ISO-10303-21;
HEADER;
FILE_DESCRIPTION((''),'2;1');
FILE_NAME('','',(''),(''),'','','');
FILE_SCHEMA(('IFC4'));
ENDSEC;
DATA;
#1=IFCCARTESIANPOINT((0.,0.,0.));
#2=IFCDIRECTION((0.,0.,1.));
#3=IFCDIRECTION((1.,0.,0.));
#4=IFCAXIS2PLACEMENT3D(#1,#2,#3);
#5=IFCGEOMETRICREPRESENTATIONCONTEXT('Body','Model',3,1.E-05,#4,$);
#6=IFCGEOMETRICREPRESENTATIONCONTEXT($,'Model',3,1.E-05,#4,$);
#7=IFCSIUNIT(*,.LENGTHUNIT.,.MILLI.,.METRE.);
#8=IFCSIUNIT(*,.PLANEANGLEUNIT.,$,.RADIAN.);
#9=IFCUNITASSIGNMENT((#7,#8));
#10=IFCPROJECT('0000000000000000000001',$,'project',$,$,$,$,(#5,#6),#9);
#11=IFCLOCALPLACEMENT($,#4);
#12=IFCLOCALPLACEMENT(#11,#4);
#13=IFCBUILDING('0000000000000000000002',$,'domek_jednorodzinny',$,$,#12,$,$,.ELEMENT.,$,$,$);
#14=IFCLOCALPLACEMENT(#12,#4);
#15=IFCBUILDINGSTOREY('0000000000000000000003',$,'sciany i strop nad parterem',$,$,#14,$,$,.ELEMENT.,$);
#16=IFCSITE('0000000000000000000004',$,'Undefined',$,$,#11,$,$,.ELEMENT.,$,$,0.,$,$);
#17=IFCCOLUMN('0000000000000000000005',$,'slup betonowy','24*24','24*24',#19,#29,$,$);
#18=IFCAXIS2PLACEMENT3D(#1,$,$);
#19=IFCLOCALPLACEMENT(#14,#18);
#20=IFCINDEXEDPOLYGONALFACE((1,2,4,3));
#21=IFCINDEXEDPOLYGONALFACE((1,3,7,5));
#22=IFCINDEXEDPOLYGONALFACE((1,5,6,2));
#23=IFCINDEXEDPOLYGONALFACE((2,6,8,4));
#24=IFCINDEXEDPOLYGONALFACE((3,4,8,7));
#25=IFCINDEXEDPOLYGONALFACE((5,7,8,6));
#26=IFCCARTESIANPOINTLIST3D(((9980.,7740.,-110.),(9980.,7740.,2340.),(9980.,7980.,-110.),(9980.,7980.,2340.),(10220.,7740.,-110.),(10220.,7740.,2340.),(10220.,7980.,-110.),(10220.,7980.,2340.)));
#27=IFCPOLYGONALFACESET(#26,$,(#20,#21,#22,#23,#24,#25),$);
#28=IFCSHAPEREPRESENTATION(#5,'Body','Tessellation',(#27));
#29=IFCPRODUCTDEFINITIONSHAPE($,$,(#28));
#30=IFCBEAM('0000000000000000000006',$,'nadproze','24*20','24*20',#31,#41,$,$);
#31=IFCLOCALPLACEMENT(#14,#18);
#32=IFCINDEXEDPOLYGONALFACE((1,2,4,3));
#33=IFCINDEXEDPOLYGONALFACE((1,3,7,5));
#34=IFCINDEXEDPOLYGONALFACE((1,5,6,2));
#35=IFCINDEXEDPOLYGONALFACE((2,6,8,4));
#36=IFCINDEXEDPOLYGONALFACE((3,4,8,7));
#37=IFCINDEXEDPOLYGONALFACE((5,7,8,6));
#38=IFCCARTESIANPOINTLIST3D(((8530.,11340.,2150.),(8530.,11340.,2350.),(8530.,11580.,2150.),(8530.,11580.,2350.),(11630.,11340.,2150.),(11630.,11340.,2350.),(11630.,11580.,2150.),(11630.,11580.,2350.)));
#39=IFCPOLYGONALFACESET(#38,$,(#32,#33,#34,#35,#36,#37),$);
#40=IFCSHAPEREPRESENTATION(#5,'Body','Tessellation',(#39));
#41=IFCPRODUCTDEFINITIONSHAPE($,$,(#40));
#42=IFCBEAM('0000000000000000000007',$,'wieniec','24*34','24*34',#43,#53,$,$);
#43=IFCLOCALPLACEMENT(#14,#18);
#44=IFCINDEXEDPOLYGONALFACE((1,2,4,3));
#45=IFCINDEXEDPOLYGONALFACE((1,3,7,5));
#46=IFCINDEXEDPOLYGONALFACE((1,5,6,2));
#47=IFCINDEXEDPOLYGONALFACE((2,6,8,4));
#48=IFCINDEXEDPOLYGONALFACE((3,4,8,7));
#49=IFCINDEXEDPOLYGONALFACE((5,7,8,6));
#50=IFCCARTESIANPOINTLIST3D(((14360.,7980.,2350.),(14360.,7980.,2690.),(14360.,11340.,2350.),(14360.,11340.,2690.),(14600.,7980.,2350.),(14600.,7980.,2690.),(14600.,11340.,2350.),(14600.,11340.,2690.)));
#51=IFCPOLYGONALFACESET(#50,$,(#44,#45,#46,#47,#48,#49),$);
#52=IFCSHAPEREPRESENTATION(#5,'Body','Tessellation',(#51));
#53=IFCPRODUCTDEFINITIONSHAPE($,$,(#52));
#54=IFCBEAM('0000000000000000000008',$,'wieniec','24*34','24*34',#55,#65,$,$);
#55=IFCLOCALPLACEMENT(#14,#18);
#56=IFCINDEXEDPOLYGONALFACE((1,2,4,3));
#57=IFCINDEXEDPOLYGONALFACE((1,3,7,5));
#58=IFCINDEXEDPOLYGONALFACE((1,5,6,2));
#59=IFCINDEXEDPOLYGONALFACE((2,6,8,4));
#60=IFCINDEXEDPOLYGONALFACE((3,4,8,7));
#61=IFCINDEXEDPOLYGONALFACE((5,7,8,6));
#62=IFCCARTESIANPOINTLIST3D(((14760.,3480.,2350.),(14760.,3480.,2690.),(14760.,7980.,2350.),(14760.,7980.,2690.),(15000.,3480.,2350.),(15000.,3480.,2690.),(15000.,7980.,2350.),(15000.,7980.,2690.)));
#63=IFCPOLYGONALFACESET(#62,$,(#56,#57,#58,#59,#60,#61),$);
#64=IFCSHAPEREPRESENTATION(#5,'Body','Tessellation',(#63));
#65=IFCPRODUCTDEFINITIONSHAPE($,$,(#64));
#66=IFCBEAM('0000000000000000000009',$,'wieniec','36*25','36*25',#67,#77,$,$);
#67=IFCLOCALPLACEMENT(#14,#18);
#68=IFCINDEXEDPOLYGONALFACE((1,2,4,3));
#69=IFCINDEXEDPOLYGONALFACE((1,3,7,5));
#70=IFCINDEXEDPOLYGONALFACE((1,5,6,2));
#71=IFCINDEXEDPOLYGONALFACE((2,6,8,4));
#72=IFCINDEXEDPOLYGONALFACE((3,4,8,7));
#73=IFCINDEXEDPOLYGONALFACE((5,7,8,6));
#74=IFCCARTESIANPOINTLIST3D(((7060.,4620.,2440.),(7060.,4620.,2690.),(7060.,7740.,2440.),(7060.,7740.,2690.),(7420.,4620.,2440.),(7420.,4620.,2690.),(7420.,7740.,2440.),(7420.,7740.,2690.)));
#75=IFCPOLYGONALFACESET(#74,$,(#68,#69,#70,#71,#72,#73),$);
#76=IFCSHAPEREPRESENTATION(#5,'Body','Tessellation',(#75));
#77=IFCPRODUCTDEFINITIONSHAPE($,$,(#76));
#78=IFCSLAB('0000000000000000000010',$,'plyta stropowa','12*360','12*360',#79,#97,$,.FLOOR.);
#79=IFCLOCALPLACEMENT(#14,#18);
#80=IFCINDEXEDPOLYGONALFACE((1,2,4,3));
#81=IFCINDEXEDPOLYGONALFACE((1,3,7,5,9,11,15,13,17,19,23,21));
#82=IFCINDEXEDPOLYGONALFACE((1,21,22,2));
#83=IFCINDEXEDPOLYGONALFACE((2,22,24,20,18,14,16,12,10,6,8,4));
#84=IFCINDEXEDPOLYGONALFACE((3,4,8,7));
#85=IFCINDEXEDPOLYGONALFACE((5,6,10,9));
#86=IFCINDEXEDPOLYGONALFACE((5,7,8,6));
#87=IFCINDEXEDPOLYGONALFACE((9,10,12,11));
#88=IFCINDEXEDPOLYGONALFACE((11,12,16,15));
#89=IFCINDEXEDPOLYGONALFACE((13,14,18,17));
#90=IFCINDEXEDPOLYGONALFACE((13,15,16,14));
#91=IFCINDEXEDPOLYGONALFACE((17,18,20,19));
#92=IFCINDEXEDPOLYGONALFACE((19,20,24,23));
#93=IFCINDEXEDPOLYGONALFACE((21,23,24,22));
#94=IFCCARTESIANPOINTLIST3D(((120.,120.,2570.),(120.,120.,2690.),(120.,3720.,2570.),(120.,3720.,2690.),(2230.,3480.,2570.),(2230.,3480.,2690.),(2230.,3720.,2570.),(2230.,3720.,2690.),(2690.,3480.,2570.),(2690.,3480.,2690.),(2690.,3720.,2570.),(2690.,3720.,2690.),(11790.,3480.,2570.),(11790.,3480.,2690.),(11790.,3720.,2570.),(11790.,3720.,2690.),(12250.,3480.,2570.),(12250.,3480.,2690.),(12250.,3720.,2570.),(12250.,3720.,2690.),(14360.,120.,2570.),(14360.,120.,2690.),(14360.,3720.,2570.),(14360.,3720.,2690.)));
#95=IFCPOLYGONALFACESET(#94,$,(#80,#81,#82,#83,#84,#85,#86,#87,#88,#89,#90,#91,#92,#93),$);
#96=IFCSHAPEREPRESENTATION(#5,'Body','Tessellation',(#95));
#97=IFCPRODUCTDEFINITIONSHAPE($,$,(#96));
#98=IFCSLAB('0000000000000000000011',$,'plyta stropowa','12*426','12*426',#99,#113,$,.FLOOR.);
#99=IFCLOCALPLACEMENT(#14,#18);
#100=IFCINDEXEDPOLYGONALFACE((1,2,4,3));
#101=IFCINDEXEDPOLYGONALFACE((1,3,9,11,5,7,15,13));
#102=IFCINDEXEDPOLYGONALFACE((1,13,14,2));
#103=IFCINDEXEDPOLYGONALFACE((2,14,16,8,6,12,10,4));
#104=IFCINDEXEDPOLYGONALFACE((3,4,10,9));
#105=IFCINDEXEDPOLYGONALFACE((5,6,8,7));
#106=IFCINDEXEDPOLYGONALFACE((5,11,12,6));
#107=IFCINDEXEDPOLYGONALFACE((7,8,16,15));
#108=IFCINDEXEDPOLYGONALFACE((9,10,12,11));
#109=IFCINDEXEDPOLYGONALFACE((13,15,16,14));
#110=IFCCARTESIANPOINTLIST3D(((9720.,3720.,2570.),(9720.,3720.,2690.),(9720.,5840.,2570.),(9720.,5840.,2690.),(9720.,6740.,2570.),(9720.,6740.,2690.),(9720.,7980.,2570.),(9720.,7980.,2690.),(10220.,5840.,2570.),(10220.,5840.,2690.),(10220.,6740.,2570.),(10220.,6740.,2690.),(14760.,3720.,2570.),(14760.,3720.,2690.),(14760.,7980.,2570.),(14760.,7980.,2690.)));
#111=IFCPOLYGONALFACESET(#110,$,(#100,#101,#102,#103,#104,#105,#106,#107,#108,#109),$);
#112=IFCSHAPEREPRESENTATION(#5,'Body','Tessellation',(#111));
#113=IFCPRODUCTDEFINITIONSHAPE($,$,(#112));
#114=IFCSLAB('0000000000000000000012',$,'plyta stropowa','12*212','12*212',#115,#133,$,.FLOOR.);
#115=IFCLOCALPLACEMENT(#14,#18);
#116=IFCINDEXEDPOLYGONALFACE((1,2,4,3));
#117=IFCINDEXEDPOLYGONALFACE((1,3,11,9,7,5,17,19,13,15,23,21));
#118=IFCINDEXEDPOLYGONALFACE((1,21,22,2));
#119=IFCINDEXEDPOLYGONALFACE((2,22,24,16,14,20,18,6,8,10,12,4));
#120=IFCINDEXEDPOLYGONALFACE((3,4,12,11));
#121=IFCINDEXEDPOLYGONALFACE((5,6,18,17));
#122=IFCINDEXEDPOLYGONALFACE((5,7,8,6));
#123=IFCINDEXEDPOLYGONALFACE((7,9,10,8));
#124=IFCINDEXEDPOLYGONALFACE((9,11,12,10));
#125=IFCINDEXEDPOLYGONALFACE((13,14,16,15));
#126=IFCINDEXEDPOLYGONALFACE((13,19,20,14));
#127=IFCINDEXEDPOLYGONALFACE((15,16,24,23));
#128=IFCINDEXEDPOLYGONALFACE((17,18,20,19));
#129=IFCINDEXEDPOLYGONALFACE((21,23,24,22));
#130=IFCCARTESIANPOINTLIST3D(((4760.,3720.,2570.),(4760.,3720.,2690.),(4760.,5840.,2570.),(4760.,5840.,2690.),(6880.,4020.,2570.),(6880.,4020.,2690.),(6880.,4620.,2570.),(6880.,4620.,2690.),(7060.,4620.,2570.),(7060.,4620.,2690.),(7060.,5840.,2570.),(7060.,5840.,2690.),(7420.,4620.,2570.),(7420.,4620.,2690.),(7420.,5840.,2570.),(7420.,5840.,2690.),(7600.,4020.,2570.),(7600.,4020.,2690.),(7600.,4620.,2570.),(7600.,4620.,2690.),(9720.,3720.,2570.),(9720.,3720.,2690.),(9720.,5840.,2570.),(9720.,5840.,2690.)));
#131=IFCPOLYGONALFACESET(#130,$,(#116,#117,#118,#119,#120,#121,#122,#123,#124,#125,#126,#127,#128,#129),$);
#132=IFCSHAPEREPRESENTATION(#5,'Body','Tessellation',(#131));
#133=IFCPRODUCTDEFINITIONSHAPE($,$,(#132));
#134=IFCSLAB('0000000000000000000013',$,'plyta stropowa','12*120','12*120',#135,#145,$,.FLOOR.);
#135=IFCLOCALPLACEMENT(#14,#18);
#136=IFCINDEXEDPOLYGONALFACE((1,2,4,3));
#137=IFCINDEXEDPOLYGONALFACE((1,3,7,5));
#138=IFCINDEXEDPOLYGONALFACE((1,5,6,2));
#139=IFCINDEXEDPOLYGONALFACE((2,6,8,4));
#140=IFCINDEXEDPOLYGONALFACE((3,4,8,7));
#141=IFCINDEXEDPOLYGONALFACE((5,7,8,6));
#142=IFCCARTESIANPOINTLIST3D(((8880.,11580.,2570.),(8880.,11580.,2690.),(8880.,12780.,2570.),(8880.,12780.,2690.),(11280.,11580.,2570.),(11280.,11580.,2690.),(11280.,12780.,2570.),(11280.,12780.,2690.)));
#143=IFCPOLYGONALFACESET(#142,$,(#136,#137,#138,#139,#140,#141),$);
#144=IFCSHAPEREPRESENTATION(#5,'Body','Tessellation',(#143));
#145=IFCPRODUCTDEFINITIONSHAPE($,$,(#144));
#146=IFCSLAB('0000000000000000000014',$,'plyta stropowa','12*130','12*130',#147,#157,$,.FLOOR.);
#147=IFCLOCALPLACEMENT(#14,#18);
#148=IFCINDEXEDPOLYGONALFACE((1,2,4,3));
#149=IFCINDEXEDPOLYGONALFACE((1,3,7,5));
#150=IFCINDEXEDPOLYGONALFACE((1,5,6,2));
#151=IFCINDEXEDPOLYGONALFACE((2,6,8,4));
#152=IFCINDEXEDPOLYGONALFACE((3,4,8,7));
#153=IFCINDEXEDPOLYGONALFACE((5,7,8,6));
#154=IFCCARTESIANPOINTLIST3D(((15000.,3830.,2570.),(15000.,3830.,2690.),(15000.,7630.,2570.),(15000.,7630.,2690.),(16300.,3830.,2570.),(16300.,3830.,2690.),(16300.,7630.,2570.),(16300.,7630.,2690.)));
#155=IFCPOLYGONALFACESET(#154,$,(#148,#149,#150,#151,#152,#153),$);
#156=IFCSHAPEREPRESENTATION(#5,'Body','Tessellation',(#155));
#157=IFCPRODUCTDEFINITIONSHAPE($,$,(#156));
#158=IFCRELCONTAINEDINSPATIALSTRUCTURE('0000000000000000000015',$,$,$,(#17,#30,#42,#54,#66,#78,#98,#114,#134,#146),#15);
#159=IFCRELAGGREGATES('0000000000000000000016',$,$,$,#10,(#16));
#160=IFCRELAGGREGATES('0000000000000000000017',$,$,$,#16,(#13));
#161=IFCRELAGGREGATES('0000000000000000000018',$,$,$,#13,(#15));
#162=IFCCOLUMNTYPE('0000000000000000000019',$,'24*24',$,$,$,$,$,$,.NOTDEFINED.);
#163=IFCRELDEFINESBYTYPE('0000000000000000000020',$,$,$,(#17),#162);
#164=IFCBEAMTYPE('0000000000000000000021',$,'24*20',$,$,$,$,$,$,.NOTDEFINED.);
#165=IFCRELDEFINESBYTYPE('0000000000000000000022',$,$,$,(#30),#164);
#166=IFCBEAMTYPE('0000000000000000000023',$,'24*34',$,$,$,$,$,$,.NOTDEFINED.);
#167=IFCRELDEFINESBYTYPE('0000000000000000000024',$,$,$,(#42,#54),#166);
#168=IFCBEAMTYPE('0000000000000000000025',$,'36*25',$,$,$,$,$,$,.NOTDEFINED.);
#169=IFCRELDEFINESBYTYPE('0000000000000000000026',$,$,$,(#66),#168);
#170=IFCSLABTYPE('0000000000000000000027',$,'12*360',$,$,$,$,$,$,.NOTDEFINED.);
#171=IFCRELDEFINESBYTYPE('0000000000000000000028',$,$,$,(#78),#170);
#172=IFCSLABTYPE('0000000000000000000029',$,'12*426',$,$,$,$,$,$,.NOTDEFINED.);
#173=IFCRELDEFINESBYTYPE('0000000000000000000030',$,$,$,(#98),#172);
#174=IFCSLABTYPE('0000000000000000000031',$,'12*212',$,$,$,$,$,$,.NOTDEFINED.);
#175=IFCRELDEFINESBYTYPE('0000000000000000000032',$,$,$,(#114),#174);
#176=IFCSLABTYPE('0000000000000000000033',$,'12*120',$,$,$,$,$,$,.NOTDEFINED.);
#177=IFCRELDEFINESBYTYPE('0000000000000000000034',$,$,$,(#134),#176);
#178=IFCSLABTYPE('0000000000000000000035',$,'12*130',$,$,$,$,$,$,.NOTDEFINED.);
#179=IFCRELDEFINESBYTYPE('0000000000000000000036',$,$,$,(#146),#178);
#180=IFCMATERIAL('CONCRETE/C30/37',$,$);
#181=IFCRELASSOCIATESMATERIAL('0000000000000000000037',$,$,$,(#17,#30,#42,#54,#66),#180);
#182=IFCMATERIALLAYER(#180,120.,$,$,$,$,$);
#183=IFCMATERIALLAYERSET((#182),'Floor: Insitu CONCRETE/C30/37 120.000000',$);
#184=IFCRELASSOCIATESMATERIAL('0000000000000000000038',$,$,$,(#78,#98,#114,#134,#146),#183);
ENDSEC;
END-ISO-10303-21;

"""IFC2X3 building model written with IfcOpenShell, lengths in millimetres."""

from ifc_helpers import new_model, si_unit, frame, origin_with_axes, origin_2d_with_axis, place, context, project, spatial, polyline, rectangle, outline, extrude, material, layer, layer_set, layer_usage, type_object, element, save


model = new_model("IFC2X3")

# Units and contexts
model_context_1 = context("Model", 3, precision=1e-05, world=origin_with_axes(), identifier="Body")
model_context_2 = context("Model", 3, precision=1e-05, world=origin_with_axes())
ifc_project = project(units=[si_unit("LENGTHUNIT", "METRE", prefix="MILLI"), si_unit("PLANEANGLEUNIT", "RADIAN")], contexts=[model_context_1, model_context_2])

# Site, building, storey
site_placement = place(None, origin_with_axes())
site = spatial("IfcSite", under=ifc_project, at=site_placement, Name="Undefined", CompositionType="ELEMENT", RefElevation=0.0)
building_placement = place(site_placement, origin_with_axes())
building = spatial("IfcBuilding", under=site, at=building_placement, Name="domek_jednorodzinny", CompositionType="ELEMENT")
storey_placement = place(building_placement, origin_with_axes())
storey = spatial("IfcBuildingStorey", under=building, at=storey_placement, Name="sciany i strop nad parterem", CompositionType="ELEMENT")

# Column
ifc_material_1 = material(Name="CONCRETE/C30/37")
column_type = type_object("IfcColumnType", Name="24*24", PredefinedType="NOTDEFINED")
column_placement = place(storey_placement, frame((10100.0, 7860.0, -110.0), z_axis=(0.0, 0.0, 1.0), x_axis=(1.0, 0.0, 0.0)))
element("IfcColumn", 1, at=column_placement, inside=storey, type_object=column_type, material=ifc_material_1, Name="slup betonowy", Description="24*24", ObjectType="24*24", context=model_context_1, shape_type="SweptSolid", body=[
    extrude(rectangle(XDim=240.0, YDim=240.0, at=origin_2d_with_axis()), frame((0.0, 0.0, 2450.0), z_axis=(0.000001, 0.000001, -1.0), x_axis=(-1.0, 0.0, 0.0)), (0.0, 0.0, 1.0), 2450.0),
])

# Beams
beam_type_1 = type_object("IfcBeamType", Name="24*20", PredefinedType="NOTDEFINED")
beam_1_placement = place(storey_placement, frame((8530.0, 11460.0, 2250.0), z_axis=(0.0, 0.0, 1.0), x_axis=(1.0, 0.0, 0.0)))
element("IfcBeam", 2, at=beam_1_placement, inside=storey, type_object=beam_type_1, material=ifc_material_1, Name="nadproze", Description="24*20", ObjectType="24*20", context=model_context_1, shape_type="SweptSolid", body=[
    extrude(rectangle(XDim=240.0, YDim=200.0, at=origin_2d_with_axis()), frame((3100.0, 0.0, 0.0), z_axis=(-1.0, 0.0, 0.0), x_axis=(0.0, -1.0, 0.0)), (0.0, 0.0, 1.0), 3100.0),
])
beam_type_2 = type_object("IfcBeamType", Name="24*34", PredefinedType="NOTDEFINED")
beam_2_placement = place(storey_placement, frame((14480.0, 11340.0, 2520.0), z_axis=(0.0, 0.0, 1.0), x_axis=(0.0, -1.0, 0.0)))
element("IfcBeam", 3, at=beam_2_placement, inside=storey, type_object=beam_type_2, material=ifc_material_1, Name="wieniec", Description="24*34", ObjectType="24*34", context=model_context_1, shape_type="SweptSolid", body=[
    extrude(rectangle(XDim=240.0, YDim=340.0, at=origin_2d_with_axis()), frame((3360.0, 0.0, 0.0), z_axis=(-1.0, 0.0, 0.0), x_axis=(0.0, -1.0, 0.0)), (0.0, 0.0, 1.0), 3360.0),
])
beam_3_placement = place(storey_placement, frame((14880.0, 7980.0, 2520.0), z_axis=(0.0, 0.0, 1.0), x_axis=(0.0, -1.0, 0.0)))
element("IfcBeam", 4, at=beam_3_placement, inside=storey, type_object=beam_type_2, material=ifc_material_1, Name="wieniec", Description="24*34", ObjectType="24*34", context=model_context_1, shape_type="SweptSolid", body=[
    extrude(rectangle(XDim=240.0, YDim=340.0, at=origin_2d_with_axis()), frame((4500.0, 0.0, 0.0), z_axis=(-1.0, 0.0, 0.0), x_axis=(0.0, -1.0, 0.0)), (0.0, 0.0, 1.0), 4500.0),
])
beam_type_3 = type_object("IfcBeamType", Name="36*25", PredefinedType="NOTDEFINED")
beam_4_placement = place(storey_placement, frame((7240.0, 4620.0, 2565.0), z_axis=(0.0, 0.0, 1.0), x_axis=(0.0, 1.0, 0.0)))
element("IfcBeam", 5, at=beam_4_placement, inside=storey, type_object=beam_type_3, material=ifc_material_1, Name="wieniec", Description="36*25", ObjectType="36*25", context=model_context_1, shape_type="SweptSolid", body=[
    extrude(rectangle(XDim=360.0, YDim=250.0, at=origin_2d_with_axis()), frame((3120.0, 0.0, 0.0), z_axis=(-1.0, 0.0, 0.0), x_axis=(0.0, -1.0, 0.0)), (0.0, 0.0, 1.0), 3120.0),
])

# Slab, openings
ifc_layer_1 = layer(ifc_material_1, 120.0)
ifc_layer_set_1 = layer_set([ifc_layer_1], Name="Floor: Insitu CONCRETE/C30/37 120.000000")
ifc_layer_usage_1 = layer_usage(ifc_layer_set_1, "AXIS3", "POSITIVE", -60.0)
slab_type_1 = type_object("IfcSlabType", Name="12*360", PredefinedType="NOTDEFINED")
slab_1_placement = place(storey_placement, frame((14360.0, 3720.0, 2630.0), z_axis=(0.0, 0.0, 1.0), x_axis=(-1.0, 0.0, 0.0)))
slab_1 = element("IfcSlab", 6, at=slab_1_placement, inside=storey, type_object=slab_type_1, material=ifc_layer_usage_1, Name="plyta stropowa", Description="12*360", ObjectType="12*360", PredefinedType="FLOOR", context=model_context_1, shape_type="SweptSolid", body=[
    extrude(outline(polyline([(0.0, 0.0), (14240.0, 0.0), (14240.0, 3600.0), (0.0, 3600.0), (0.0, 0.0)])), frame((0.0, 0.0, -60.0), z_axis=(0.0, 0.0, 1.0), x_axis=(1.0, 0.0, 0.0)), (0.0, 0.0, 1.0), 120.0),
])
opening_1_placement = place(storey_placement, frame((14360.0, 3720.0, 2630.0), z_axis=(0.0, 0.0, 1.0), x_axis=(-1.0, 0.0, 0.0)))
element("IfcOpeningElement", 7, at=opening_1_placement, cuts=slab_1, ObjectType="Recess", context=model_context_1, shape_type="SweptSolid", body=[
    extrude(outline(polyline([(0.0, 0.0), (460.0, 0.0), (460.0, 240.0), (0.0, 240.0), (0.0, 0.0)])), frame((12130.0, 240.0, -112.5), z_axis=(0.0, 0.0, 1.0), x_axis=(-1.0, 0.0, 0.0)), (0.0, 0.0, 1.0), 225.0),
])
opening_2_placement = place(storey_placement, frame((14360.0, 3720.0, 2630.0), z_axis=(0.0, 0.0, 1.0), x_axis=(-1.0, 0.0, 0.0)))
element("IfcOpeningElement", 8, at=opening_2_placement, cuts=slab_1, ObjectType="Recess", context=model_context_1, shape_type="SweptSolid", body=[
    extrude(outline(polyline([(0.0, 0.0), (460.0, 0.0), (460.0, 240.0), (0.0, 240.0), (0.0, 0.0)])), frame((2570.0, 240.0, -112.5), z_axis=(0.0, 0.0, 1.0), x_axis=(-1.0, 0.0, 0.0)), (0.0, 0.0, 1.0), 225.0),
])

# Slab, opening
ifc_layer_usage_2 = layer_usage(ifc_layer_set_1, "AXIS3", "POSITIVE", -60.0)
slab_type_2 = type_object("IfcSlabType", Name="12*426", PredefinedType="NOTDEFINED")
slab_2_placement = place(storey_placement, frame((14760.0, 7980.0, 2630.0), z_axis=(0.0, 0.0, 1.0), x_axis=(-1.0, 0.0, 0.0)))
slab_2 = element("IfcSlab", 9, at=slab_2_placement, inside=storey, type_object=slab_type_2, material=ifc_layer_usage_2, Name="plyta stropowa", Description="12*426", ObjectType="12*426", PredefinedType="FLOOR", context=model_context_1, shape_type="SweptSolid", body=[
    extrude(outline(polyline([(0.0, 0.0), (5040.0, 0.0), (5040.0, 4260.0), (0.0, 4260.0), (0.0, 0.0)])), frame((0.0, 0.0, -60.0), z_axis=(0.0, 0.0, 1.0), x_axis=(1.0, 0.0, 0.0)), (0.0, 0.0, 1.0), 120.0),
])
opening_3_placement = place(storey_placement, frame((14760.0, 7980.0, 2630.0), z_axis=(0.0, 0.0, 1.0), x_axis=(-1.0, 0.0, 0.0)))
element("IfcOpeningElement", 10, at=opening_3_placement, cuts=slab_2, ObjectType="Recess", context=model_context_1, shape_type="SweptSolid", body=[
    extrude(outline(polyline([(0.0, 0.0), (500.0, 0.0), (500.0, 900.0), (0.0, 900.0), (0.0, 0.0)])), frame((4540.0, 2140.0, 112.5), z_axis=(0.000001, 0.000001, -1.0), x_axis=(1.0, 0.0, 0.0)), (0.0, 0.0, 1.0), 225.0),
])

# Slab, openings
ifc_layer_usage_3 = layer_usage(ifc_layer_set_1, "AXIS3", "POSITIVE", -60.0)
slab_type_3 = type_object("IfcSlabType", Name="12*212", PredefinedType="NOTDEFINED")
slab_3_placement = place(storey_placement, frame((9720.0, 5840.0, 2630.0), z_axis=(0.0, 0.0, 1.0), x_axis=(-1.0, 0.0, 0.0)))
slab_3 = element("IfcSlab", 11, at=slab_3_placement, inside=storey, type_object=slab_type_3, material=ifc_layer_usage_3, Name="plyta stropowa", Description="12*212", ObjectType="12*212", PredefinedType="FLOOR", context=model_context_1, shape_type="SweptSolid", body=[
    extrude(outline(polyline([(0.0, 0.0), (4960.0, 0.0), (4960.0, 2120.0), (0.0, 2120.0), (0.0, 0.0)])), frame((0.0, 0.0, -60.0), z_axis=(0.0, 0.0, 1.0), x_axis=(1.0, 0.0, 0.0)), (0.0, 0.0, 1.0), 120.0),
])
opening_4_placement = place(storey_placement, frame((9720.0, 5840.0, 2630.0), z_axis=(0.0, 0.0, 1.0), x_axis=(-1.0, 0.0, 0.0)))
element("IfcOpeningElement", 12, at=opening_4_placement, cuts=slab_3, ObjectType="Recess", context=model_context_1, shape_type="SweptSolid", body=[
    extrude(outline(polyline([(0.0, 0.0), (720.0, 0.0), (720.0, 600.0), (0.0, 600.0), (0.0, 0.0)])), frame((2840.0, 1220.0, 112.5), z_axis=(0.000001, 0.000001, -1.0), x_axis=(-1.0, 0.000046, 0.0)), (0.0, 0.0, 1.0), 225.0),
])
opening_5_placement = place(storey_placement, frame((9720.0, 5840.0, 2630.0), z_axis=(0.0, 0.0, 1.0), x_axis=(-1.0, 0.0, 0.0)))
element("IfcOpeningElement", 13, at=opening_5_placement, cuts=slab_3, ObjectType="Recess", context=model_context_1, shape_type="SweptSolid", body=[
    extrude(outline(polyline([(0.0, 0.0), (1220.0, 0.0), (1220.0, 360.0), (0.0, 360.1), (0.0, 0.0)])), frame((2300.0, 1220.0, -62.5), z_axis=(0.0, 0.0, 1.0), x_axis=(0.0, -1.0, 0.0)), (0.0, 0.0, 1.0), 125.0),
])

# Slabs
ifc_layer_usage_4 = layer_usage(ifc_layer_set_1, "AXIS3", "POSITIVE", -60.0)
slab_type_4 = type_object("IfcSlabType", Name="12*120", PredefinedType="NOTDEFINED")
slab_4_placement = place(storey_placement, frame((11280.0, 12780.0, 2630.0), z_axis=(0.0, 0.0, 1.0), x_axis=(-1.0, 0.0, 0.0)))
element("IfcSlab", 14, at=slab_4_placement, inside=storey, type_object=slab_type_4, material=ifc_layer_usage_4, Name="plyta stropowa", Description="12*120", ObjectType="12*120", PredefinedType="FLOOR", context=model_context_1, shape_type="SweptSolid", body=[
    extrude(outline(polyline([(0.0, 0.0), (2400.0, 0.0), (2400.0, 1200.0), (0.0, 1200.0), (0.0, 0.0)])), frame((0.0, 0.0, -60.0), z_axis=(0.0, 0.0, 1.0), x_axis=(1.0, 0.0, 0.0)), (0.0, 0.0, 1.0), 120.0),
])
ifc_layer_usage_5 = layer_usage(ifc_layer_set_1, "AXIS3", "POSITIVE", -60.0)
slab_type_5 = type_object("IfcSlabType", Name="12*130", PredefinedType="NOTDEFINED")
slab_5_placement = place(storey_placement, frame((16300.0, 7630.0, 2630.0), z_axis=(0.0, 0.0, 1.0), x_axis=(-1.0, 0.0, 0.0)))
element("IfcSlab", 15, at=slab_5_placement, inside=storey, type_object=slab_type_5, material=ifc_layer_usage_5, Name="plyta stropowa", Description="12*130", ObjectType="12*130", PredefinedType="FLOOR", context=model_context_1, shape_type="SweptSolid", body=[
    extrude(outline(polyline([(0.0, 0.0), (1300.0, 0.0), (1300.0, 3800.0), (0.0, 3800.0), (0.0, 0.0)])), frame((0.0, 0.0, -60.0), z_axis=(0.0, 0.0, 1.0), x_axis=(1.0, 0.0, 0.0)), (0.0, 0.0, 1.0), 120.0),
])

save(model, "model.ifc")
